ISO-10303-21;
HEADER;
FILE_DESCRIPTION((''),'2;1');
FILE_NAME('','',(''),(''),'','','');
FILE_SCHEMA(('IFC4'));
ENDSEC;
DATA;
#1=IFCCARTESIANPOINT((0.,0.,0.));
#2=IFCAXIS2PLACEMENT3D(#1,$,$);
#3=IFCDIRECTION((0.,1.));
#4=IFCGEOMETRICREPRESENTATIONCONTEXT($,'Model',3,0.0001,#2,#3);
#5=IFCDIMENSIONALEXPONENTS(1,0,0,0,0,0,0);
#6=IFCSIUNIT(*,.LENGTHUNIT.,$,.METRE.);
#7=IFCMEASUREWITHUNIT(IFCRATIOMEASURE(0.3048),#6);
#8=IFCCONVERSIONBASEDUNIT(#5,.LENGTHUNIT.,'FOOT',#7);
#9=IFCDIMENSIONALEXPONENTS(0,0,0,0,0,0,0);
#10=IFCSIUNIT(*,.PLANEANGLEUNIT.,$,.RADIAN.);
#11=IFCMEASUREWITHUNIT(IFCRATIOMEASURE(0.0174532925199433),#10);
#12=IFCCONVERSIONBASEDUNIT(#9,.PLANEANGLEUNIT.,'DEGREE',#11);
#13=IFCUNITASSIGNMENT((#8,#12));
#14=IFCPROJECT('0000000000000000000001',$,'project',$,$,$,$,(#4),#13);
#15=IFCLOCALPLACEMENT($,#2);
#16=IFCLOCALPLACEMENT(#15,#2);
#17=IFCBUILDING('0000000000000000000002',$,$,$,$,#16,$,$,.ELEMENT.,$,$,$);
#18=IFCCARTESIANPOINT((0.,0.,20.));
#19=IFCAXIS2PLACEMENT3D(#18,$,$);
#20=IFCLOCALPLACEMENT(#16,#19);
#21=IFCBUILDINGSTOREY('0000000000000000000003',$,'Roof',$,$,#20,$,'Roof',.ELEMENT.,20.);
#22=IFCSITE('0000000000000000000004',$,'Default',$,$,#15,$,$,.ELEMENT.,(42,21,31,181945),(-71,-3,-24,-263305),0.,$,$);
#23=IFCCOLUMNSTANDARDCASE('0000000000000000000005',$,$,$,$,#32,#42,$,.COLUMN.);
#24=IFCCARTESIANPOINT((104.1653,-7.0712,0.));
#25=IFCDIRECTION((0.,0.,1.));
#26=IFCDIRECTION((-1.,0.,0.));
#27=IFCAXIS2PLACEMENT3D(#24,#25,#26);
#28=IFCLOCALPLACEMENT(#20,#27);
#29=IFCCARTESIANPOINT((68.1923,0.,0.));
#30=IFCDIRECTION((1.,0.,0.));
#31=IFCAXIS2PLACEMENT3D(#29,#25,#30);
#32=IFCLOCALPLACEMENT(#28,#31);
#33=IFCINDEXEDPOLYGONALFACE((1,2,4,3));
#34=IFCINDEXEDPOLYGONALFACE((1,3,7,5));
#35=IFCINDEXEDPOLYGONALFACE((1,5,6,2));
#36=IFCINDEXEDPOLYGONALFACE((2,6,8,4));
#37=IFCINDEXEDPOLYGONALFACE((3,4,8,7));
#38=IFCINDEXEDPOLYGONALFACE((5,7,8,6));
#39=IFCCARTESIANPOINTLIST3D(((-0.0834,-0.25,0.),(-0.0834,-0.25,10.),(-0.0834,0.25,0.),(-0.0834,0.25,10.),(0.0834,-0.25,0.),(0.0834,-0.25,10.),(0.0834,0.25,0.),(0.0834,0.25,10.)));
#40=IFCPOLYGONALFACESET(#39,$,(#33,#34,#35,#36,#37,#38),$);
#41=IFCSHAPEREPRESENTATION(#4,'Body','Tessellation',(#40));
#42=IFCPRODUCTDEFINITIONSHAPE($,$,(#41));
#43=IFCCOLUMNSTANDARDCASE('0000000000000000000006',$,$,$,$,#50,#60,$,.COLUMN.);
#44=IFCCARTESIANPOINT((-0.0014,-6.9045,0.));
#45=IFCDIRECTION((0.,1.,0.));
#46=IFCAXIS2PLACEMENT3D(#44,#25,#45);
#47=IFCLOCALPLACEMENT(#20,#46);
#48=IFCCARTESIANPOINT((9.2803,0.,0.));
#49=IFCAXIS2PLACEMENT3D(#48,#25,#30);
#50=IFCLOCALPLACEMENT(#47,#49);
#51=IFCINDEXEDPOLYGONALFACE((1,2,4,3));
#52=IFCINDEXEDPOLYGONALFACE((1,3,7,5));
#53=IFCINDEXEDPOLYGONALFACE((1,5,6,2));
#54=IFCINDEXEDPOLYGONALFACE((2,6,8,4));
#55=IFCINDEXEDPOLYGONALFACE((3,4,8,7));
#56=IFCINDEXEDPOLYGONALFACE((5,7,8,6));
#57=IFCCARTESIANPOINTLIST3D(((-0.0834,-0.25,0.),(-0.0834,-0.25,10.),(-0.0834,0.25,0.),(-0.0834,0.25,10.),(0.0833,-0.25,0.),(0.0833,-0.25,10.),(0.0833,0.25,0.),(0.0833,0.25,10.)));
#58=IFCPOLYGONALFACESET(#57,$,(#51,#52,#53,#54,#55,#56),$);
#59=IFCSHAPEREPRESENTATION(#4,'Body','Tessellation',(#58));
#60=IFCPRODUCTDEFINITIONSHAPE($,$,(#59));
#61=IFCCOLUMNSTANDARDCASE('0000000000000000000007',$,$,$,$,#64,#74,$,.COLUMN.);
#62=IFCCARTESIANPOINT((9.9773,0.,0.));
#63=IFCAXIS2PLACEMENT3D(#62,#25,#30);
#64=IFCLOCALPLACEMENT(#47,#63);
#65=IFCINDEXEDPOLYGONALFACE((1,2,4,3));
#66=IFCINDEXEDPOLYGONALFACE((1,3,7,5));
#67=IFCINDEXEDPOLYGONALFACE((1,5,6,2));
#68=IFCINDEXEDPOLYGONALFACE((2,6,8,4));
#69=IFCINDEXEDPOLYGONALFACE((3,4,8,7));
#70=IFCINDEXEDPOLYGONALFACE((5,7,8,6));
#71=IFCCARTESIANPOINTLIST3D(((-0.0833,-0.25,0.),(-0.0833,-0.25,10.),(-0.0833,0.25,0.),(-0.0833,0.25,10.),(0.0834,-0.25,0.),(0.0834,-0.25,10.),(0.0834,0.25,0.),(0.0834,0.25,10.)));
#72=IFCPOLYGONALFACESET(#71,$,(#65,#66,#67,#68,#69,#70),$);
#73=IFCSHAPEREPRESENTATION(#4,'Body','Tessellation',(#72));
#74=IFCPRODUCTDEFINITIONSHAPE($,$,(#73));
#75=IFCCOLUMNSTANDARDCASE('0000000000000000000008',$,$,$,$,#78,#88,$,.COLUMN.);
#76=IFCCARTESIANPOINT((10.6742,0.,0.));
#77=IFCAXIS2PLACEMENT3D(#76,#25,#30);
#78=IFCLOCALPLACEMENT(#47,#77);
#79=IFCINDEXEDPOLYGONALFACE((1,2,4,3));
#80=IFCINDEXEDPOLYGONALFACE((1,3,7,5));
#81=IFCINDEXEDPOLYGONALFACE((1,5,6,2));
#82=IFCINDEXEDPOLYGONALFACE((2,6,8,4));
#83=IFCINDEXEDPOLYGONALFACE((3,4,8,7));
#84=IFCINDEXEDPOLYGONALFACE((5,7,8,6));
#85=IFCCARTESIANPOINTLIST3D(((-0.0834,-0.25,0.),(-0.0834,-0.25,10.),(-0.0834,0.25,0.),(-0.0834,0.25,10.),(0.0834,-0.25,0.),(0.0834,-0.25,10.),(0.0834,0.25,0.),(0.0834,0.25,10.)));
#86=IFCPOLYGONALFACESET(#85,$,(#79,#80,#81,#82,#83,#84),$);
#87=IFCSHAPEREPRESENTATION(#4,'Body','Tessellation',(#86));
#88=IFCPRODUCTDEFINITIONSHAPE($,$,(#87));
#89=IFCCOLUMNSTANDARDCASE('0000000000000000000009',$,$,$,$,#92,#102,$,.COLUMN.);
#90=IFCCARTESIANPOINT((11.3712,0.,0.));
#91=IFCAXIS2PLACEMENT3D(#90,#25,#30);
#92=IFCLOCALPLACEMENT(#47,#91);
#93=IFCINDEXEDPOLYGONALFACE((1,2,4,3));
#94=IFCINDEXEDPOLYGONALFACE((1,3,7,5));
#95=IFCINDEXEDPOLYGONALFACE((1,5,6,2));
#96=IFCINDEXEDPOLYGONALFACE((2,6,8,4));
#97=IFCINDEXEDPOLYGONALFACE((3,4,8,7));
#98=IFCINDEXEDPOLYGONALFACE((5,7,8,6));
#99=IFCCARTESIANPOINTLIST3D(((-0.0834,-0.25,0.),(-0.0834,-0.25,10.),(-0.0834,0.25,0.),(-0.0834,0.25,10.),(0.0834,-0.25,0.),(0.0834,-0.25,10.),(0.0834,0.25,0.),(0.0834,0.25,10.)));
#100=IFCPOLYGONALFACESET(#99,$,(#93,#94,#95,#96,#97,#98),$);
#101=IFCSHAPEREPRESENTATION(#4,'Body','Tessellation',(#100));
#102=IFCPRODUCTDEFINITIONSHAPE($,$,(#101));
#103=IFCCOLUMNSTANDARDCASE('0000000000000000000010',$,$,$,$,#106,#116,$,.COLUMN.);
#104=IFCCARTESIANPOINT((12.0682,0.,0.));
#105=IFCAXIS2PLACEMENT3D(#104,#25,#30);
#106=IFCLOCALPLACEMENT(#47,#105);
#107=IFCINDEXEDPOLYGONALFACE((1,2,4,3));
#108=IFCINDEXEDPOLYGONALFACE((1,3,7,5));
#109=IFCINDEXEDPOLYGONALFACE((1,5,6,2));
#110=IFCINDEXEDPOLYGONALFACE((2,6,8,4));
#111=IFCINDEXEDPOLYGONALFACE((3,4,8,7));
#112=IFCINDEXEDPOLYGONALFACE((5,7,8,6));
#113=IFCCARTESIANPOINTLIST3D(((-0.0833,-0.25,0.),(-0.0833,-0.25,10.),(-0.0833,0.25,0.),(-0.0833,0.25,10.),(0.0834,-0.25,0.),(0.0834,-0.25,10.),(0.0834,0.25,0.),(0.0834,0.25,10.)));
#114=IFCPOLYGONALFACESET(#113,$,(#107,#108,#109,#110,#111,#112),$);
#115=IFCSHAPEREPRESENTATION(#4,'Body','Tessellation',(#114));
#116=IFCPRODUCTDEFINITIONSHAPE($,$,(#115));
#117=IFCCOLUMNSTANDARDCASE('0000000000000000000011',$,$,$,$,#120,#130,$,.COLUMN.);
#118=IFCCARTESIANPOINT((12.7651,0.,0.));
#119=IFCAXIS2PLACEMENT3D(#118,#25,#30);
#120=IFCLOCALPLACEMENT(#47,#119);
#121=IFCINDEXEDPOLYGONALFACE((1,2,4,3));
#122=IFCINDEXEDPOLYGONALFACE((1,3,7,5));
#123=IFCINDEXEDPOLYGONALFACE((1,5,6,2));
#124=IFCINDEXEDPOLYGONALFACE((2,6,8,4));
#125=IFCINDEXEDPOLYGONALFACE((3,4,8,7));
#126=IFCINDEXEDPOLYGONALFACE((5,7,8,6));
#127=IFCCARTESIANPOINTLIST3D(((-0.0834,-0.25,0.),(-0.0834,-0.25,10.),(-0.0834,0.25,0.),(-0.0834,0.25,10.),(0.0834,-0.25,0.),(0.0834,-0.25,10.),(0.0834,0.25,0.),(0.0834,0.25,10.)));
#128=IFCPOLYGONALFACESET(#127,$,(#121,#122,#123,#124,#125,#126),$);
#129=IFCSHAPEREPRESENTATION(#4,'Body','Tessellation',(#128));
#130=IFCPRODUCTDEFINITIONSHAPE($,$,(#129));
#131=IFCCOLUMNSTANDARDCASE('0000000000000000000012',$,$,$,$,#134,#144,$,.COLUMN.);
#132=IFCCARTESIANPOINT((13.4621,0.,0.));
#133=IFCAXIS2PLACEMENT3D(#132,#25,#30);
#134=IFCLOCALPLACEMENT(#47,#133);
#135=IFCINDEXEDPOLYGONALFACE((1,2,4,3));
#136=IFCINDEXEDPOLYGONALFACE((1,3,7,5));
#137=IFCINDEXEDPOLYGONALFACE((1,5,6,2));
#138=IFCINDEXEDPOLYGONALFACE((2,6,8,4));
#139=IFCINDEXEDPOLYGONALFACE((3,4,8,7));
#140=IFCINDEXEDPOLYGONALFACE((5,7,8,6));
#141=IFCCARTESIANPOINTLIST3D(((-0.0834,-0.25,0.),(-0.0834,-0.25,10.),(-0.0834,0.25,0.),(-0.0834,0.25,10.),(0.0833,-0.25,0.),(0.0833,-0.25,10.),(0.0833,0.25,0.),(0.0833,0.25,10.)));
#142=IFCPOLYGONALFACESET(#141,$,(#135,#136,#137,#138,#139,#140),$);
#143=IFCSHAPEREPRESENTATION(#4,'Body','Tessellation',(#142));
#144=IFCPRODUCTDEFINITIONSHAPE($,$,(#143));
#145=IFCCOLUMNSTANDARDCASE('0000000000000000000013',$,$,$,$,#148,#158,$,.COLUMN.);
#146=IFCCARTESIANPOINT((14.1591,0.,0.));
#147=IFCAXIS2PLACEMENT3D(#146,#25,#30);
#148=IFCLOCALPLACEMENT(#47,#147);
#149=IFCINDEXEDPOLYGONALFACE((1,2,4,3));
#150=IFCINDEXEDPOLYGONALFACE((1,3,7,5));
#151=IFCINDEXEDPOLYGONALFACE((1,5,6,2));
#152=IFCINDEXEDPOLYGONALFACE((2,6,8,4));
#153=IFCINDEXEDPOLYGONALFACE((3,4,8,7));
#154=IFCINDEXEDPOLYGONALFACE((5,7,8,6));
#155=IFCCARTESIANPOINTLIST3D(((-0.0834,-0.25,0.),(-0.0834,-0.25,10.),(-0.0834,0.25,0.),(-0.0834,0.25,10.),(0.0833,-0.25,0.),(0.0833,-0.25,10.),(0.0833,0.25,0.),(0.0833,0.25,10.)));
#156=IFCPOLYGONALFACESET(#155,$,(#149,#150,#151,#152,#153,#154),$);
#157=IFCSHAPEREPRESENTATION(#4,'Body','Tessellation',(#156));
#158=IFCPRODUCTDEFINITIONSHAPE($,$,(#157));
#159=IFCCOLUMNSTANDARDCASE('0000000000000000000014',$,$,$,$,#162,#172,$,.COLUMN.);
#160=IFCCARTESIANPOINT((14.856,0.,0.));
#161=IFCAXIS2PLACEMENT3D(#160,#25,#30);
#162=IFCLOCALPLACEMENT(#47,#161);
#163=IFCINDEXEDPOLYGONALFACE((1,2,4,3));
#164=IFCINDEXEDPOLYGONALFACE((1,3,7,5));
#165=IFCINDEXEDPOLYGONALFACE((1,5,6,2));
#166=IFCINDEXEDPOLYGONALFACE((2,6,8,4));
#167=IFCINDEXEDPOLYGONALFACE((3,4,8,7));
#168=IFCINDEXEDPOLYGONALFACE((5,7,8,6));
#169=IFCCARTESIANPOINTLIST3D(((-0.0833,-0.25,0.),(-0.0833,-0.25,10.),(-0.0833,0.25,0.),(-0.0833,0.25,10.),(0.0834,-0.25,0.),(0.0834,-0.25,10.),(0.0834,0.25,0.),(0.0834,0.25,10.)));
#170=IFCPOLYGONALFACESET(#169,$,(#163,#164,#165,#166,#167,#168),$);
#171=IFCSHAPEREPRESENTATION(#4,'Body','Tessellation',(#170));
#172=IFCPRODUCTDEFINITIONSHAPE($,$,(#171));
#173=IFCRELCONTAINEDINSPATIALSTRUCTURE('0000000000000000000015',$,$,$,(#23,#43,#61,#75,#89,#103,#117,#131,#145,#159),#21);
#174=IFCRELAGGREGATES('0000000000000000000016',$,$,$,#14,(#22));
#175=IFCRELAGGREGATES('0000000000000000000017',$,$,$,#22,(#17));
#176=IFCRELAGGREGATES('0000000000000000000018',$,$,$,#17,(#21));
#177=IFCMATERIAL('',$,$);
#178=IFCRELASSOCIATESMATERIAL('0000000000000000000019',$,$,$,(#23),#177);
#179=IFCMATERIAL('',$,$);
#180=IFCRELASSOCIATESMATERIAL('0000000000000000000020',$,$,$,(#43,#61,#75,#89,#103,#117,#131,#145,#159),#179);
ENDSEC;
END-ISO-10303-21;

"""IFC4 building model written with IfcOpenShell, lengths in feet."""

from ifc_helpers import new_model, entity, si_unit, converted_unit, direction, frame, origin, place, context, project, spatial, rectangle, extrude, material, element, save


model = new_model("IFC4")

# Units and contexts
model_context = context("Model", 3, precision=0.0001, world=origin(), true_north=direction((0.0, 1.0)))
ifc_project = project(units=[converted_unit("LENGTHUNIT", "FOOT", entity("IfcRatioMeasure", 0.3048), si_unit("LENGTHUNIT", "METRE"), dimensions=[1, 0, 0, 0, 0, 0, 0]), converted_unit("PLANEANGLEUNIT", "DEGREE", entity("IfcRatioMeasure", 0.0174532925199433), si_unit("PLANEANGLEUNIT", "RADIAN"), dimensions=[0, 0, 0, 0, 0, 0, 0])], contexts=[model_context])

# Site, building, storey
site_placement = place(None, origin())
site = spatial("IfcSite", under=ifc_project, at=site_placement, Name="Default", CompositionType="ELEMENT", RefLatitude=(42, 21, 31, 181945), RefLongitude=(-71, -3, -24, -263305), RefElevation=0.0)
building_placement = place(site_placement, origin())
building = spatial("IfcBuilding", under=site, at=building_placement, CompositionType="ELEMENT")
storey_placement = place(building_placement, frame((0.0, 0.0, 20.0)))
storey = spatial("IfcBuildingStorey", under=building, at=storey_placement, Name="Roof", LongName="Roof", CompositionType="ELEMENT", Elevation=20.0)

# Columns
ifc_material_1 = material(Name="")
placement_1 = place(storey_placement, frame((104.1653, -7.0712, 0.0), z_axis=(0.0, 0.0, 1.0), x_axis=(-1.0, 0.0, 0.0)))
for number, where, z_axis, x_axis in (
    (1, (68.1923, 0.0, 0.0), (0.0, 0.0, 1.0), (1.0, 0.0, 0.0)),
):
    element("IfcColumnStandardCase", number, at=place(placement_1, frame(where, z_axis=z_axis, x_axis=x_axis)), inside=storey, material=ifc_material_1, PredefinedType="COLUMN", context=model_context, shape_type="SweptSolid", body=[
        extrude(rectangle(XDim=0.1667, YDim=0.5), origin(), (0.0, 0.0, 1.0), 10.0),
    ])
ifc_material_2 = material(Name="")
placement_2 = place(storey_placement, frame((-0.0014, -6.9045, 0.0), z_axis=(0.0, 0.0, 1.0), x_axis=(0.0, 1.0, 0.0)))
for number, where, z_axis, x_axis in (
    (2, (9.2803, 0.0, 0.0), (0.0, 0.0, 1.0), (1.0, 0.0, 0.0)),
    (3, (9.9773, 0.0, 0.0), (0.0, 0.0, 1.0), (1.0, 0.0, 0.0)),
    (4, (10.6742, 0.0, 0.0), (0.0, 0.0, 1.0), (1.0, 0.0, 0.0)),
    (5, (11.3712, 0.0, 0.0), (0.0, 0.0, 1.0), (1.0, 0.0, 0.0)),
    (6, (12.0682, 0.0, 0.0), (0.0, 0.0, 1.0), (1.0, 0.0, 0.0)),
    (7, (12.7651, 0.0, 0.0), (0.0, 0.0, 1.0), (1.0, 0.0, 0.0)),
    (8, (13.4621, 0.0, 0.0), (0.0, 0.0, 1.0), (1.0, 0.0, 0.0)),
    (9, (14.1591, 0.0, 0.0), (0.0, 0.0, 1.0), (1.0, 0.0, 0.0)),
    (10, (14.856, 0.0, 0.0), (0.0, 0.0, 1.0), (1.0, 0.0, 0.0)),
):
    element("IfcColumnStandardCase", number, at=place(placement_2, frame(where, z_axis=z_axis, x_axis=x_axis)), inside=storey, material=ifc_material_2, PredefinedType="COLUMN", context=model_context, shape_type="SweptSolid", body=[
        extrude(rectangle(XDim=0.1667, YDim=0.5), origin(), (0.0, 0.0, 1.0), 10.0),
    ])

save(model, "model.ifc")
